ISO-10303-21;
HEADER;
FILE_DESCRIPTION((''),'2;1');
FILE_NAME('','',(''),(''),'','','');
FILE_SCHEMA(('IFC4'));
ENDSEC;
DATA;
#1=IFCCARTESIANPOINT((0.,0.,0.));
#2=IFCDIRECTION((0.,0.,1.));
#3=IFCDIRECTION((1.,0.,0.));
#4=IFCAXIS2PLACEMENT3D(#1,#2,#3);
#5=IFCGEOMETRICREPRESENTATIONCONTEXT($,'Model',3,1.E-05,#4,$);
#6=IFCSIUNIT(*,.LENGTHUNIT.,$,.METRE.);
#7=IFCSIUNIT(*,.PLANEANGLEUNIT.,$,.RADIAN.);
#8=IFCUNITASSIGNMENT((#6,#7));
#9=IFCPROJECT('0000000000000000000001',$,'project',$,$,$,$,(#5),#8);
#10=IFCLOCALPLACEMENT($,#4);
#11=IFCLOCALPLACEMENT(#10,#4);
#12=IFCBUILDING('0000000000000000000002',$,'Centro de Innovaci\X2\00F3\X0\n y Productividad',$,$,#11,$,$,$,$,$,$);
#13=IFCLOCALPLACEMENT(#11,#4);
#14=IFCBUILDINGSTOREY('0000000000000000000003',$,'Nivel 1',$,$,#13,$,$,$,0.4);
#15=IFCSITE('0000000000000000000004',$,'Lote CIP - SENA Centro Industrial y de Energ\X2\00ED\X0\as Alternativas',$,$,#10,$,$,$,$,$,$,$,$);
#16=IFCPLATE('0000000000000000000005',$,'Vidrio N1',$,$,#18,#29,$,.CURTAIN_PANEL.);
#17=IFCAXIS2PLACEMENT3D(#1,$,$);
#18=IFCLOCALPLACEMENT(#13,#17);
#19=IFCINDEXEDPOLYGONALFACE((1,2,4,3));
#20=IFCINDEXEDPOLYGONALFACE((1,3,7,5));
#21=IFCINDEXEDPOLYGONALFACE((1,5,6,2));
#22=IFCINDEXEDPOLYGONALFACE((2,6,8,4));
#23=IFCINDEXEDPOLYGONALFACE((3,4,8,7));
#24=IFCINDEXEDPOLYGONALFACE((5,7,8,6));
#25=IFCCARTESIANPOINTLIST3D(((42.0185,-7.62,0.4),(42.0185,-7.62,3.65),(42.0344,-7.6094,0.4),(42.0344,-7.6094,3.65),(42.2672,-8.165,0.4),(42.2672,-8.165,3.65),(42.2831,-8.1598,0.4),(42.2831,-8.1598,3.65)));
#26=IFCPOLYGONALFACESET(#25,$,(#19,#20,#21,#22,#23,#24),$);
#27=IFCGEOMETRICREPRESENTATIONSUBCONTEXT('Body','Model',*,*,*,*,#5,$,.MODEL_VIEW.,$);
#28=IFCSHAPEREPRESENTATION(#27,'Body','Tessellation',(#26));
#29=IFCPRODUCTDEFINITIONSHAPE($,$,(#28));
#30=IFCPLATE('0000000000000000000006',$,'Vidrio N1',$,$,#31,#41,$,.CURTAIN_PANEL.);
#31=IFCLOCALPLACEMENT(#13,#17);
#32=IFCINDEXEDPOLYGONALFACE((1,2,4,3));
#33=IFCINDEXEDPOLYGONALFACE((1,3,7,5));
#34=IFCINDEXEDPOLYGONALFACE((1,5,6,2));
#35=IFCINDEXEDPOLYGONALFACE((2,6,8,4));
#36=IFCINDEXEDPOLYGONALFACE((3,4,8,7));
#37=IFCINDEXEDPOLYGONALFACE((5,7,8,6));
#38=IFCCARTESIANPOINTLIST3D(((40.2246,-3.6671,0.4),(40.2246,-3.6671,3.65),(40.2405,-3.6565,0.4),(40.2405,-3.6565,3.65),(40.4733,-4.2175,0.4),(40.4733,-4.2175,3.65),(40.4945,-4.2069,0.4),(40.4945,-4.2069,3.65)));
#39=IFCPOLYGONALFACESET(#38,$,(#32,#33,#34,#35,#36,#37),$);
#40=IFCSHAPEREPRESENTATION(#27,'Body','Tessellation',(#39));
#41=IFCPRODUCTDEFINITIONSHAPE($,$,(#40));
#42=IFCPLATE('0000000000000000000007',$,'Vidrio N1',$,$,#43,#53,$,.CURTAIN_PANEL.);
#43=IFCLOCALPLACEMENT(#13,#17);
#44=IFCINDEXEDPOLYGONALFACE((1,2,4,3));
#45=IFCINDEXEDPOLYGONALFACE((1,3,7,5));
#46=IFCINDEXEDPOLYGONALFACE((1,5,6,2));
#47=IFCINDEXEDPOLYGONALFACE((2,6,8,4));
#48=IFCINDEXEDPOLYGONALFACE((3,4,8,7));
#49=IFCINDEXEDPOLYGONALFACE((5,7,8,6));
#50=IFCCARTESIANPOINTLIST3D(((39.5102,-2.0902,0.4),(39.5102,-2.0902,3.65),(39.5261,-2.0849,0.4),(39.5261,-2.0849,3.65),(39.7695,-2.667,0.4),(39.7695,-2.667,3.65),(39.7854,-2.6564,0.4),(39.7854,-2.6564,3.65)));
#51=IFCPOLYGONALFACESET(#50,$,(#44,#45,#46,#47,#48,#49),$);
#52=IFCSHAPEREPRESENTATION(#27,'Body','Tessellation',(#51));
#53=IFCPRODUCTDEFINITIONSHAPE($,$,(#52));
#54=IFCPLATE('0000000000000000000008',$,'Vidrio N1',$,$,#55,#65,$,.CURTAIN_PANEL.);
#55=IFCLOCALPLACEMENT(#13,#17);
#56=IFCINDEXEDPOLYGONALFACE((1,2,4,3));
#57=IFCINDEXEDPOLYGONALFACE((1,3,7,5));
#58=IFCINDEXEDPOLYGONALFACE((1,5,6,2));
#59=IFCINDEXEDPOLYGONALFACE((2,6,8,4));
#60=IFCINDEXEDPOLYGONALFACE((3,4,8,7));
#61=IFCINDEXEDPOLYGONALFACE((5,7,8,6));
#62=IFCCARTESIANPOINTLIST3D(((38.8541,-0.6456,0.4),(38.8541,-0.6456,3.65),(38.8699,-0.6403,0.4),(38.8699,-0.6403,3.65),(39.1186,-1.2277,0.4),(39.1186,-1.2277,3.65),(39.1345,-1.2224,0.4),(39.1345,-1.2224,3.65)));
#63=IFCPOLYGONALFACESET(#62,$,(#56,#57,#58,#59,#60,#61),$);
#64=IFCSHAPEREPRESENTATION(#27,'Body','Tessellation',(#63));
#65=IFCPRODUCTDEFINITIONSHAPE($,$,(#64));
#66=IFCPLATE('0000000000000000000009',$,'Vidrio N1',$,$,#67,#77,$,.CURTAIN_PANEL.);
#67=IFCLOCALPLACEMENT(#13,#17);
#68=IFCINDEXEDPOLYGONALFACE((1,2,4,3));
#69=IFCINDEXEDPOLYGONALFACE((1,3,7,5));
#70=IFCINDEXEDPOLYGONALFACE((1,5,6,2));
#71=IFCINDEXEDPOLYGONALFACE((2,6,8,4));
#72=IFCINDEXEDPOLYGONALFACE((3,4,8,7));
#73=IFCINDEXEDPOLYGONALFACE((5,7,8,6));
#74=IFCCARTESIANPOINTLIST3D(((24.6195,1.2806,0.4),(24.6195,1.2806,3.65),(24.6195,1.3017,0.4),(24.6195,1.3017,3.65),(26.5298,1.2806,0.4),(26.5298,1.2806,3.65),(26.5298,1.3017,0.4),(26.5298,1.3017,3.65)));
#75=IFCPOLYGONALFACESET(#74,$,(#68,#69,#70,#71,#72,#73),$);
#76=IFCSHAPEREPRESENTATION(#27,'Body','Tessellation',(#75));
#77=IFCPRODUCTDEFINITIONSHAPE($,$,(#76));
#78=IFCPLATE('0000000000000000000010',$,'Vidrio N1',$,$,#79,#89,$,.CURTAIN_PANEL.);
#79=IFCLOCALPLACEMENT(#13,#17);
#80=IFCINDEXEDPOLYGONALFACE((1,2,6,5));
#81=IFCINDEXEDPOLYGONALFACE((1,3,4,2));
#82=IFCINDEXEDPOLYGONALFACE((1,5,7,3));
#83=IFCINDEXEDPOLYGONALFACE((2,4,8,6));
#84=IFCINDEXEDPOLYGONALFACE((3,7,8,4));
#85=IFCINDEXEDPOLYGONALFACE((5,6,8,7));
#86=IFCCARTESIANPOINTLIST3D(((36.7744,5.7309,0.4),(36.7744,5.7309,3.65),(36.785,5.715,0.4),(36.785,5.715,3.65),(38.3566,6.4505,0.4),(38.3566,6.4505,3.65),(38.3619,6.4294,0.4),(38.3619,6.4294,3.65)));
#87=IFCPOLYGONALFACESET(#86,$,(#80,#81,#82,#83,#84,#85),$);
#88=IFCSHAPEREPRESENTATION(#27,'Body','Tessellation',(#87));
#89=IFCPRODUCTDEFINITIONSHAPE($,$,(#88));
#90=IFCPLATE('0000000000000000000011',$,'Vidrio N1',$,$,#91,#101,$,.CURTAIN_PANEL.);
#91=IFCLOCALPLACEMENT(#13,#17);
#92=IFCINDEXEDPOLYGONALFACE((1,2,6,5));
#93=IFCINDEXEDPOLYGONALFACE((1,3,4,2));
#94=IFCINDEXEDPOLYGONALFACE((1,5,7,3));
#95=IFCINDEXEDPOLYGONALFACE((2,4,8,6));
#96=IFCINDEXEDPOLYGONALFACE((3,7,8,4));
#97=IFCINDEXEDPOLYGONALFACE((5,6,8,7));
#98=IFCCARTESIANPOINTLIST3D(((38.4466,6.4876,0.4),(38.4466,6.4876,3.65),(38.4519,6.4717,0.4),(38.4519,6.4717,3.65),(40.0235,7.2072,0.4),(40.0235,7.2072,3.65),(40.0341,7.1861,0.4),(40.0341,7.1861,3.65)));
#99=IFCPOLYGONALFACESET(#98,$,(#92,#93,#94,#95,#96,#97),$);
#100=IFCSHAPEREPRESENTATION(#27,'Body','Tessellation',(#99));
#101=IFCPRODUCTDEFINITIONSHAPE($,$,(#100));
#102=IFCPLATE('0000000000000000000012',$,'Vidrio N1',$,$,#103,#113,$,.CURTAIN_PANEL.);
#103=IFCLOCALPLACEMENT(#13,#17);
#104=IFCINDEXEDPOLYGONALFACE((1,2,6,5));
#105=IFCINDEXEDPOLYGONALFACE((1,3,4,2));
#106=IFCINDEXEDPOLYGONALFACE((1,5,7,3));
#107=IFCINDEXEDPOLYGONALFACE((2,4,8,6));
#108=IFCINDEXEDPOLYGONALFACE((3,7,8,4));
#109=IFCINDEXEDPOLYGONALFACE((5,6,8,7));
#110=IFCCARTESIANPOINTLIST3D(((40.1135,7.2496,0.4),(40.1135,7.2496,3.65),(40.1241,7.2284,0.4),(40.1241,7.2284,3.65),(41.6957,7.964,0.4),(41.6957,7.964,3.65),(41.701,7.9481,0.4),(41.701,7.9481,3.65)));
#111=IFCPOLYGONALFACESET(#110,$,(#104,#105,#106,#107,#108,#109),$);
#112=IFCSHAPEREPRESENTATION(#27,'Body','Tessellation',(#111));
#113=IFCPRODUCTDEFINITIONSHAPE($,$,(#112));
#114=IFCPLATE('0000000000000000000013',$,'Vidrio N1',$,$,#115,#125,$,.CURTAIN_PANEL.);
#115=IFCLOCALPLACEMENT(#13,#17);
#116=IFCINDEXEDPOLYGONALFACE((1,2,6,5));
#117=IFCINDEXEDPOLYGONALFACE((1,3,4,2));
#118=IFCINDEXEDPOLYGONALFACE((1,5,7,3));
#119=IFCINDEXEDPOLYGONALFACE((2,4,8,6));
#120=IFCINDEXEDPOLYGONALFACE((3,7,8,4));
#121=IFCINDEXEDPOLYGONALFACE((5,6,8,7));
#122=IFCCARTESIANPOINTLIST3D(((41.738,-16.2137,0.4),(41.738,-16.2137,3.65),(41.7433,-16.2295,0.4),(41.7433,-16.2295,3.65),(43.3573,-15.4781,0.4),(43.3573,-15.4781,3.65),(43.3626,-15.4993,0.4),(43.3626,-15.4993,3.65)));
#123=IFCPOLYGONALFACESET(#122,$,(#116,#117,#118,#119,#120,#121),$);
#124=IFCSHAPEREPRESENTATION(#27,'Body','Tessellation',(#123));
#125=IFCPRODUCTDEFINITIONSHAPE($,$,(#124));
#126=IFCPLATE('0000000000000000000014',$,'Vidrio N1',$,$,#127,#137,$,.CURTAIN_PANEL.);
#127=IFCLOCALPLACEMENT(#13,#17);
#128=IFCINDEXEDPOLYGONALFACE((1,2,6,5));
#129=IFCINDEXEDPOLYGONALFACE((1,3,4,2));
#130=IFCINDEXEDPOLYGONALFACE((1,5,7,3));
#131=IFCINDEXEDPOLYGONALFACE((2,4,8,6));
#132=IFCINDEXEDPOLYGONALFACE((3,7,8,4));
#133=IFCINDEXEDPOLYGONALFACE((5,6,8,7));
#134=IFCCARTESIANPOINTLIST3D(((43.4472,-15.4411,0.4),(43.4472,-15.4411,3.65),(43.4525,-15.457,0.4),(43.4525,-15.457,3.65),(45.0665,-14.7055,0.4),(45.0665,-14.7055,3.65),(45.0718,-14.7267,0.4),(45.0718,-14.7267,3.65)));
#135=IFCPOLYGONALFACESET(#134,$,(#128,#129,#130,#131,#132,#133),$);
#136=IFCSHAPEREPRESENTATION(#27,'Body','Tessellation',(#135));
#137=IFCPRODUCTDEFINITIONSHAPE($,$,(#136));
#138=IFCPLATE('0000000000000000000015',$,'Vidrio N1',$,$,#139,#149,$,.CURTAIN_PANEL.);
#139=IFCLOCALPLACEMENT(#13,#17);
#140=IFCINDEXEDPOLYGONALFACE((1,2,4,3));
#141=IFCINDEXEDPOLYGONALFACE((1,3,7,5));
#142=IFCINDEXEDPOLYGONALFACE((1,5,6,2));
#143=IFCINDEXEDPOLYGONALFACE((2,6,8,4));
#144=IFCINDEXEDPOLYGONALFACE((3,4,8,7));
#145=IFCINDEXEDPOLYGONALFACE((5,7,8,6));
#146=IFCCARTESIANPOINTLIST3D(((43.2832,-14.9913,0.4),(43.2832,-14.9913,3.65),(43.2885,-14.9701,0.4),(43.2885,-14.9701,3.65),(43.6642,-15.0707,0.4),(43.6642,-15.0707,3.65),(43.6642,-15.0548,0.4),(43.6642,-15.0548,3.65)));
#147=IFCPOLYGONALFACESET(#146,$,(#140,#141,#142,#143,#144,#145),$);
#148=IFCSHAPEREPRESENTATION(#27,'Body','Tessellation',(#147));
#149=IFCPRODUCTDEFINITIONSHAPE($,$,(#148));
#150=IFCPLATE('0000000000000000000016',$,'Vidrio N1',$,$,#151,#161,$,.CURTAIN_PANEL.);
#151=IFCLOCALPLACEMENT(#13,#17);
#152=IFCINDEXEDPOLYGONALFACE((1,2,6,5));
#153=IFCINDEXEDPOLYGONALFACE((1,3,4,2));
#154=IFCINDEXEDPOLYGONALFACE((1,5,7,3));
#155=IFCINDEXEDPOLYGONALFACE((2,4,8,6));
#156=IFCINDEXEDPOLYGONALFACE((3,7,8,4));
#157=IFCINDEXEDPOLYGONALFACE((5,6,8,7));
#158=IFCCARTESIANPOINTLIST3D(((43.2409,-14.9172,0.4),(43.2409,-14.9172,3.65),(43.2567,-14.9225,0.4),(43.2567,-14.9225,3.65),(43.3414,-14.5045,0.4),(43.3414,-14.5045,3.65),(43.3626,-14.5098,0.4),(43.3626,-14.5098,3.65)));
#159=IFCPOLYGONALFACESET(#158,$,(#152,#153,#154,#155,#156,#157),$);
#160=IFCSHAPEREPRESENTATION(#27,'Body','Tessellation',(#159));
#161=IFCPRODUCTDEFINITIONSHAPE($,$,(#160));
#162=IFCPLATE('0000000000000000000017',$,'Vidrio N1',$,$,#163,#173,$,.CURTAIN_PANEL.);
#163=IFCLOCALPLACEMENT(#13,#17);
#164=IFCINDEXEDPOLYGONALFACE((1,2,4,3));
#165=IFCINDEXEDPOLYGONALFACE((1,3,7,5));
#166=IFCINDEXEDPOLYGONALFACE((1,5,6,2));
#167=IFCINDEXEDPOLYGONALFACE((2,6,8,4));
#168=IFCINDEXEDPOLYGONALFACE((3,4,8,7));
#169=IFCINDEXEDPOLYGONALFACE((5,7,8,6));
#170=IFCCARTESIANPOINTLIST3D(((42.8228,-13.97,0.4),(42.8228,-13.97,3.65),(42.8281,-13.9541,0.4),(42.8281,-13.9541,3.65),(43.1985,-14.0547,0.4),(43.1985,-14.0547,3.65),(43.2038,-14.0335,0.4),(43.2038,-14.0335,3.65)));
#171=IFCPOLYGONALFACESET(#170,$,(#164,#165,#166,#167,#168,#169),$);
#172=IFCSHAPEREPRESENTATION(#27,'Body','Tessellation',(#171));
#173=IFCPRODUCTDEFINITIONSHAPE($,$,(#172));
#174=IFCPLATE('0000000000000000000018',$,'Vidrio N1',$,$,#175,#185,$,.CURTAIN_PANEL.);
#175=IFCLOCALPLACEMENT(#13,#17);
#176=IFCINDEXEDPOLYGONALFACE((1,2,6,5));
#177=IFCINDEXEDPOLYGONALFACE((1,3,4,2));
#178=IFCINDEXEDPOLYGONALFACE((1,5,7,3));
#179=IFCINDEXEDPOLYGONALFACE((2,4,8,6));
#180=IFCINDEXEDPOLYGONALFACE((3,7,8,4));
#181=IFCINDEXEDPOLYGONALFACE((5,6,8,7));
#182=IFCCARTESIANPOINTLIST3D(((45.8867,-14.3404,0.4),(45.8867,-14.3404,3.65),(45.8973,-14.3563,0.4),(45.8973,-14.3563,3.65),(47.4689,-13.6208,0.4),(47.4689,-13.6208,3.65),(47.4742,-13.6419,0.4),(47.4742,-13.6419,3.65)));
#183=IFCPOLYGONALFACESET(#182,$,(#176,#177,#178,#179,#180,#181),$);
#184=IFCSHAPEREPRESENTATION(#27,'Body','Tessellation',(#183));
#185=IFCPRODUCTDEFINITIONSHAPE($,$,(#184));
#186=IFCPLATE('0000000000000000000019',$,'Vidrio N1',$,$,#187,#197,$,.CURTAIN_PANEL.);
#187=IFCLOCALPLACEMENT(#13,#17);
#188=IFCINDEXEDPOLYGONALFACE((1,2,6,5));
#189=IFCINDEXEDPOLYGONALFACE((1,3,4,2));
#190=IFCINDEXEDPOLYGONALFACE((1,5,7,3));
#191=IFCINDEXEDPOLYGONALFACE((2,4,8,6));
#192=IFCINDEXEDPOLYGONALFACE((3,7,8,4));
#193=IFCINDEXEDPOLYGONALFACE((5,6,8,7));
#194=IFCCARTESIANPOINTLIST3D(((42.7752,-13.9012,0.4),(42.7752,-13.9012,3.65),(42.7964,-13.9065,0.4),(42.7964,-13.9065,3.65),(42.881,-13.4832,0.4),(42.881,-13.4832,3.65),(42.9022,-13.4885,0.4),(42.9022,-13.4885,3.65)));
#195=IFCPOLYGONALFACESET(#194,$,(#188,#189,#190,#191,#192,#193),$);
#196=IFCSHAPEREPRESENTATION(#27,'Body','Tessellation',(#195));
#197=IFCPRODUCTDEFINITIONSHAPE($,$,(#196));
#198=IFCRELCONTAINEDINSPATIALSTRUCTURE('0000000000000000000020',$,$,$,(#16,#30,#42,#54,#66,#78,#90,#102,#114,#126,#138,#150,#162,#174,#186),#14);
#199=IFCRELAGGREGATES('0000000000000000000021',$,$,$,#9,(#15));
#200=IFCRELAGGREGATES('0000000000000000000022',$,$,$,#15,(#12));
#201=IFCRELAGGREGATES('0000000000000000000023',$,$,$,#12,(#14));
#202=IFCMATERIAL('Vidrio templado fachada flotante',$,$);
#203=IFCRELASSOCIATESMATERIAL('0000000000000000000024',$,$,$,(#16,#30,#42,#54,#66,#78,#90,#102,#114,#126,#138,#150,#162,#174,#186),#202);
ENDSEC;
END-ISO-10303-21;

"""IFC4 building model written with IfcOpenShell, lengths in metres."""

from ifc_helpers import new_model, si_unit, frame, origin_with_axes, place, context, subcontext, project, spatial, polyline, outline, extrude, material, element, save


model = new_model("IFC4")

# Units and contexts
model_context = context("Model", 3, precision=1e-05, world=origin_with_axes())
body_context = subcontext(model_context, "Body", "Model", "MODEL_VIEW")
ifc_project = project(units=[si_unit("LENGTHUNIT", "METRE"), si_unit("PLANEANGLEUNIT", "RADIAN")], contexts=[model_context])

# Site, building, storey
site_placement = place(None, origin_with_axes())
site = spatial("IfcSite", under=ifc_project, at=site_placement, Name="Lote CIP - SENA Centro Industrial y de Energías Alternativas")
building_placement = place(site_placement, origin_with_axes())
building = spatial("IfcBuilding", under=site, at=building_placement, Name="Centro de Innovación y Productividad")
storey_placement = place(building_placement, origin_with_axes())
storey = spatial("IfcBuildingStorey", under=building, at=storey_placement, Name="Nivel 1", Elevation=0.4)

# Plates
ifc_material = material(Name="Vidrio templado fachada flotante")
plate_1_placement = place(storey_placement, origin_with_axes())
element("IfcPlate", 1, at=plate_1_placement, inside=storey, material=ifc_material, Name="Vidrio N1", PredefinedType="CURTAIN_PANEL", context=body_context, shape_type="SweptSolid", body=[
    extrude(outline(polyline([(42.0185, -7.62), (42.0344, -7.6094), (42.2831, -8.1598), (42.2672, -8.165), (42.0185, -7.62)])), frame((0.0, 0.0, 0.4)), (0.0, 0.0, 1.0), 3.25),
])
plate_2_placement = place(storey_placement, origin_with_axes())
element("IfcPlate", 2, at=plate_2_placement, inside=storey, material=ifc_material, Name="Vidrio N1", PredefinedType="CURTAIN_PANEL", context=body_context, shape_type="SweptSolid", body=[
    extrude(outline(polyline([(40.2405, -3.6565), (40.4945, -4.2069), (40.4733, -4.2175), (40.2246, -3.6671), (40.2405, -3.6565)])), frame((0.0, 0.0, 0.4)), (0.0, 0.0, 1.0), 3.25),
])
plate_3_placement = place(storey_placement, origin_with_axes())
element("IfcPlate", 3, at=plate_3_placement, inside=storey, material=ifc_material, Name="Vidrio N1", PredefinedType="CURTAIN_PANEL", context=body_context, shape_type="SweptSolid", body=[
    extrude(outline(polyline([(39.7854, -2.6564), (39.7695, -2.667), (39.5102, -2.0902), (39.5261, -2.0849), (39.7854, -2.6564)])), frame((0.0, 0.0, 0.4)), (0.0, 0.0, 1.0), 3.25),
])
plate_4_placement = place(storey_placement, origin_with_axes())
element("IfcPlate", 4, at=plate_4_placement, inside=storey, material=ifc_material, Name="Vidrio N1", PredefinedType="CURTAIN_PANEL", context=body_context, shape_type="SweptSolid", body=[
    extrude(outline(polyline([(38.8541, -0.6456), (38.8699, -0.6403), (39.1345, -1.2224), (39.1186, -1.2277), (38.8541, -0.6456)])), frame((0.0, 0.0, 0.4)), (0.0, 0.0, 1.0), 3.25),
])
plate_5_placement = place(storey_placement, origin_with_axes())
element("IfcPlate", 5, at=plate_5_placement, inside=storey, material=ifc_material, Name="Vidrio N1", PredefinedType="CURTAIN_PANEL", context=body_context, shape_type="SweptSolid", body=[
    extrude(outline(polyline([(24.6195, 1.2806), (24.6195, 1.3017), (26.5298, 1.3017), (26.5298, 1.2806), (24.6195, 1.2806)])), frame((0.0, 0.0, 0.4)), (0.0, 0.0, 1.0), 3.25),
])
plate_6_placement = place(storey_placement, origin_with_axes())
element("IfcPlate", 6, at=plate_6_placement, inside=storey, material=ifc_material, Name="Vidrio N1", PredefinedType="CURTAIN_PANEL", context=body_context, shape_type="SweptSolid", body=[
    extrude(outline(polyline([(38.3566, 6.4505), (38.3619, 6.4294), (36.785, 5.715), (36.7744, 5.7309), (38.3566, 6.4505)])), frame((0.0, 0.0, 0.4)), (0.0, 0.0, 1.0), 3.25),
])
plate_7_placement = place(storey_placement, origin_with_axes())
element("IfcPlate", 7, at=plate_7_placement, inside=storey, material=ifc_material, Name="Vidrio N1", PredefinedType="CURTAIN_PANEL", context=body_context, shape_type="SweptSolid", body=[
    extrude(outline(polyline([(38.4466, 6.4876), (40.0235, 7.2072), (40.0341, 7.1861), (38.4519, 6.4717), (38.4466, 6.4876)])), frame((0.0, 0.0, 0.4)), (0.0, 0.0, 1.0), 3.25),
])
plate_8_placement = place(storey_placement, origin_with_axes())
element("IfcPlate", 8, at=plate_8_placement, inside=storey, material=ifc_material, Name="Vidrio N1", PredefinedType="CURTAIN_PANEL", context=body_context, shape_type="SweptSolid", body=[
    extrude(outline(polyline([(40.1135, 7.2496), (41.6957, 7.964), (41.701, 7.9481), (40.1241, 7.2284), (40.1135, 7.2496)])), frame((0.0, 0.0, 0.4)), (0.0, 0.0, 1.0), 3.25),
])
plate_9_placement = place(storey_placement, origin_with_axes())
element("IfcPlate", 9, at=plate_9_placement, inside=storey, material=ifc_material, Name="Vidrio N1", PredefinedType="CURTAIN_PANEL", context=body_context, shape_type="SweptSolid", body=[
    extrude(outline(polyline([(41.7433, -16.2295), (41.738, -16.2137), (43.3573, -15.4781), (43.3626, -15.4993), (41.7433, -16.2295)])), frame((0.0, 0.0, 0.4)), (0.0, 0.0, 1.0), 3.25),
])
plate_10_placement = place(storey_placement, origin_with_axes())
element("IfcPlate", 10, at=plate_10_placement, inside=storey, material=ifc_material, Name="Vidrio N1", PredefinedType="CURTAIN_PANEL", context=body_context, shape_type="SweptSolid", body=[
    extrude(outline(polyline([(45.0718, -14.7267), (43.4525, -15.457), (43.4472, -15.4411), (45.0665, -14.7055), (45.0718, -14.7267)])), frame((0.0, 0.0, 0.4)), (0.0, 0.0, 1.0), 3.25),
])
plate_11_placement = place(storey_placement, origin_with_axes())
element("IfcPlate", 11, at=plate_11_placement, inside=storey, material=ifc_material, Name="Vidrio N1", PredefinedType="CURTAIN_PANEL", context=body_context, shape_type="SweptSolid", body=[
    extrude(outline(polyline([(43.2885, -14.9701), (43.6642, -15.0548), (43.6642, -15.0707), (43.2832, -14.9913), (43.2885, -14.9701)])), frame((0.0, 0.0, 0.4)), (0.0, 0.0, 1.0), 3.25),
])
plate_12_placement = place(storey_placement, origin_with_axes())
element("IfcPlate", 12, at=plate_12_placement, inside=storey, material=ifc_material, Name="Vidrio N1", PredefinedType="CURTAIN_PANEL", context=body_context, shape_type="SweptSolid", body=[
    extrude(outline(polyline([(43.2567, -14.9225), (43.2409, -14.9172), (43.3414, -14.5045), (43.3626, -14.5098), (43.2567, -14.9225)])), frame((0.0, 0.0, 0.4)), (0.0, 0.0, 1.0), 3.25),
])
plate_13_placement = place(storey_placement, origin_with_axes())
element("IfcPlate", 13, at=plate_13_placement, inside=storey, material=ifc_material, Name="Vidrio N1", PredefinedType="CURTAIN_PANEL", context=body_context, shape_type="SweptSolid", body=[
    extrude(outline(polyline([(42.8228, -13.97), (42.8281, -13.9541), (43.2038, -14.0335), (43.1985, -14.0547), (42.8228, -13.97)])), frame((0.0, 0.0, 0.4)), (0.0, 0.0, 1.0), 3.25),
])
plate_14_placement = place(storey_placement, origin_with_axes())
element("IfcPlate", 14, at=plate_14_placement, inside=storey, material=ifc_material, Name="Vidrio N1", PredefinedType="CURTAIN_PANEL", context=body_context, shape_type="SweptSolid", body=[
    extrude(outline(polyline([(47.4742, -13.6419), (45.8973, -14.3563), (45.8867, -14.3404), (47.4689, -13.6208), (47.4742, -13.6419)])), frame((0.0, 0.0, 0.4)), (0.0, 0.0, 1.0), 3.25),
])
plate_15_placement = place(storey_placement, origin_with_axes())
element("IfcPlate", 15, at=plate_15_placement, inside=storey, material=ifc_material, Name="Vidrio N1", PredefinedType="CURTAIN_PANEL", context=body_context, shape_type="SweptSolid", body=[
    extrude(outline(polyline([(42.9022, -13.4885), (42.7964, -13.9065), (42.7752, -13.9012), (42.881, -13.4832), (42.9022, -13.4885)])), frame((0.0, 0.0, 0.4)), (0.0, 0.0, 1.0), 3.25),
])

save(model, "model.ifc")
